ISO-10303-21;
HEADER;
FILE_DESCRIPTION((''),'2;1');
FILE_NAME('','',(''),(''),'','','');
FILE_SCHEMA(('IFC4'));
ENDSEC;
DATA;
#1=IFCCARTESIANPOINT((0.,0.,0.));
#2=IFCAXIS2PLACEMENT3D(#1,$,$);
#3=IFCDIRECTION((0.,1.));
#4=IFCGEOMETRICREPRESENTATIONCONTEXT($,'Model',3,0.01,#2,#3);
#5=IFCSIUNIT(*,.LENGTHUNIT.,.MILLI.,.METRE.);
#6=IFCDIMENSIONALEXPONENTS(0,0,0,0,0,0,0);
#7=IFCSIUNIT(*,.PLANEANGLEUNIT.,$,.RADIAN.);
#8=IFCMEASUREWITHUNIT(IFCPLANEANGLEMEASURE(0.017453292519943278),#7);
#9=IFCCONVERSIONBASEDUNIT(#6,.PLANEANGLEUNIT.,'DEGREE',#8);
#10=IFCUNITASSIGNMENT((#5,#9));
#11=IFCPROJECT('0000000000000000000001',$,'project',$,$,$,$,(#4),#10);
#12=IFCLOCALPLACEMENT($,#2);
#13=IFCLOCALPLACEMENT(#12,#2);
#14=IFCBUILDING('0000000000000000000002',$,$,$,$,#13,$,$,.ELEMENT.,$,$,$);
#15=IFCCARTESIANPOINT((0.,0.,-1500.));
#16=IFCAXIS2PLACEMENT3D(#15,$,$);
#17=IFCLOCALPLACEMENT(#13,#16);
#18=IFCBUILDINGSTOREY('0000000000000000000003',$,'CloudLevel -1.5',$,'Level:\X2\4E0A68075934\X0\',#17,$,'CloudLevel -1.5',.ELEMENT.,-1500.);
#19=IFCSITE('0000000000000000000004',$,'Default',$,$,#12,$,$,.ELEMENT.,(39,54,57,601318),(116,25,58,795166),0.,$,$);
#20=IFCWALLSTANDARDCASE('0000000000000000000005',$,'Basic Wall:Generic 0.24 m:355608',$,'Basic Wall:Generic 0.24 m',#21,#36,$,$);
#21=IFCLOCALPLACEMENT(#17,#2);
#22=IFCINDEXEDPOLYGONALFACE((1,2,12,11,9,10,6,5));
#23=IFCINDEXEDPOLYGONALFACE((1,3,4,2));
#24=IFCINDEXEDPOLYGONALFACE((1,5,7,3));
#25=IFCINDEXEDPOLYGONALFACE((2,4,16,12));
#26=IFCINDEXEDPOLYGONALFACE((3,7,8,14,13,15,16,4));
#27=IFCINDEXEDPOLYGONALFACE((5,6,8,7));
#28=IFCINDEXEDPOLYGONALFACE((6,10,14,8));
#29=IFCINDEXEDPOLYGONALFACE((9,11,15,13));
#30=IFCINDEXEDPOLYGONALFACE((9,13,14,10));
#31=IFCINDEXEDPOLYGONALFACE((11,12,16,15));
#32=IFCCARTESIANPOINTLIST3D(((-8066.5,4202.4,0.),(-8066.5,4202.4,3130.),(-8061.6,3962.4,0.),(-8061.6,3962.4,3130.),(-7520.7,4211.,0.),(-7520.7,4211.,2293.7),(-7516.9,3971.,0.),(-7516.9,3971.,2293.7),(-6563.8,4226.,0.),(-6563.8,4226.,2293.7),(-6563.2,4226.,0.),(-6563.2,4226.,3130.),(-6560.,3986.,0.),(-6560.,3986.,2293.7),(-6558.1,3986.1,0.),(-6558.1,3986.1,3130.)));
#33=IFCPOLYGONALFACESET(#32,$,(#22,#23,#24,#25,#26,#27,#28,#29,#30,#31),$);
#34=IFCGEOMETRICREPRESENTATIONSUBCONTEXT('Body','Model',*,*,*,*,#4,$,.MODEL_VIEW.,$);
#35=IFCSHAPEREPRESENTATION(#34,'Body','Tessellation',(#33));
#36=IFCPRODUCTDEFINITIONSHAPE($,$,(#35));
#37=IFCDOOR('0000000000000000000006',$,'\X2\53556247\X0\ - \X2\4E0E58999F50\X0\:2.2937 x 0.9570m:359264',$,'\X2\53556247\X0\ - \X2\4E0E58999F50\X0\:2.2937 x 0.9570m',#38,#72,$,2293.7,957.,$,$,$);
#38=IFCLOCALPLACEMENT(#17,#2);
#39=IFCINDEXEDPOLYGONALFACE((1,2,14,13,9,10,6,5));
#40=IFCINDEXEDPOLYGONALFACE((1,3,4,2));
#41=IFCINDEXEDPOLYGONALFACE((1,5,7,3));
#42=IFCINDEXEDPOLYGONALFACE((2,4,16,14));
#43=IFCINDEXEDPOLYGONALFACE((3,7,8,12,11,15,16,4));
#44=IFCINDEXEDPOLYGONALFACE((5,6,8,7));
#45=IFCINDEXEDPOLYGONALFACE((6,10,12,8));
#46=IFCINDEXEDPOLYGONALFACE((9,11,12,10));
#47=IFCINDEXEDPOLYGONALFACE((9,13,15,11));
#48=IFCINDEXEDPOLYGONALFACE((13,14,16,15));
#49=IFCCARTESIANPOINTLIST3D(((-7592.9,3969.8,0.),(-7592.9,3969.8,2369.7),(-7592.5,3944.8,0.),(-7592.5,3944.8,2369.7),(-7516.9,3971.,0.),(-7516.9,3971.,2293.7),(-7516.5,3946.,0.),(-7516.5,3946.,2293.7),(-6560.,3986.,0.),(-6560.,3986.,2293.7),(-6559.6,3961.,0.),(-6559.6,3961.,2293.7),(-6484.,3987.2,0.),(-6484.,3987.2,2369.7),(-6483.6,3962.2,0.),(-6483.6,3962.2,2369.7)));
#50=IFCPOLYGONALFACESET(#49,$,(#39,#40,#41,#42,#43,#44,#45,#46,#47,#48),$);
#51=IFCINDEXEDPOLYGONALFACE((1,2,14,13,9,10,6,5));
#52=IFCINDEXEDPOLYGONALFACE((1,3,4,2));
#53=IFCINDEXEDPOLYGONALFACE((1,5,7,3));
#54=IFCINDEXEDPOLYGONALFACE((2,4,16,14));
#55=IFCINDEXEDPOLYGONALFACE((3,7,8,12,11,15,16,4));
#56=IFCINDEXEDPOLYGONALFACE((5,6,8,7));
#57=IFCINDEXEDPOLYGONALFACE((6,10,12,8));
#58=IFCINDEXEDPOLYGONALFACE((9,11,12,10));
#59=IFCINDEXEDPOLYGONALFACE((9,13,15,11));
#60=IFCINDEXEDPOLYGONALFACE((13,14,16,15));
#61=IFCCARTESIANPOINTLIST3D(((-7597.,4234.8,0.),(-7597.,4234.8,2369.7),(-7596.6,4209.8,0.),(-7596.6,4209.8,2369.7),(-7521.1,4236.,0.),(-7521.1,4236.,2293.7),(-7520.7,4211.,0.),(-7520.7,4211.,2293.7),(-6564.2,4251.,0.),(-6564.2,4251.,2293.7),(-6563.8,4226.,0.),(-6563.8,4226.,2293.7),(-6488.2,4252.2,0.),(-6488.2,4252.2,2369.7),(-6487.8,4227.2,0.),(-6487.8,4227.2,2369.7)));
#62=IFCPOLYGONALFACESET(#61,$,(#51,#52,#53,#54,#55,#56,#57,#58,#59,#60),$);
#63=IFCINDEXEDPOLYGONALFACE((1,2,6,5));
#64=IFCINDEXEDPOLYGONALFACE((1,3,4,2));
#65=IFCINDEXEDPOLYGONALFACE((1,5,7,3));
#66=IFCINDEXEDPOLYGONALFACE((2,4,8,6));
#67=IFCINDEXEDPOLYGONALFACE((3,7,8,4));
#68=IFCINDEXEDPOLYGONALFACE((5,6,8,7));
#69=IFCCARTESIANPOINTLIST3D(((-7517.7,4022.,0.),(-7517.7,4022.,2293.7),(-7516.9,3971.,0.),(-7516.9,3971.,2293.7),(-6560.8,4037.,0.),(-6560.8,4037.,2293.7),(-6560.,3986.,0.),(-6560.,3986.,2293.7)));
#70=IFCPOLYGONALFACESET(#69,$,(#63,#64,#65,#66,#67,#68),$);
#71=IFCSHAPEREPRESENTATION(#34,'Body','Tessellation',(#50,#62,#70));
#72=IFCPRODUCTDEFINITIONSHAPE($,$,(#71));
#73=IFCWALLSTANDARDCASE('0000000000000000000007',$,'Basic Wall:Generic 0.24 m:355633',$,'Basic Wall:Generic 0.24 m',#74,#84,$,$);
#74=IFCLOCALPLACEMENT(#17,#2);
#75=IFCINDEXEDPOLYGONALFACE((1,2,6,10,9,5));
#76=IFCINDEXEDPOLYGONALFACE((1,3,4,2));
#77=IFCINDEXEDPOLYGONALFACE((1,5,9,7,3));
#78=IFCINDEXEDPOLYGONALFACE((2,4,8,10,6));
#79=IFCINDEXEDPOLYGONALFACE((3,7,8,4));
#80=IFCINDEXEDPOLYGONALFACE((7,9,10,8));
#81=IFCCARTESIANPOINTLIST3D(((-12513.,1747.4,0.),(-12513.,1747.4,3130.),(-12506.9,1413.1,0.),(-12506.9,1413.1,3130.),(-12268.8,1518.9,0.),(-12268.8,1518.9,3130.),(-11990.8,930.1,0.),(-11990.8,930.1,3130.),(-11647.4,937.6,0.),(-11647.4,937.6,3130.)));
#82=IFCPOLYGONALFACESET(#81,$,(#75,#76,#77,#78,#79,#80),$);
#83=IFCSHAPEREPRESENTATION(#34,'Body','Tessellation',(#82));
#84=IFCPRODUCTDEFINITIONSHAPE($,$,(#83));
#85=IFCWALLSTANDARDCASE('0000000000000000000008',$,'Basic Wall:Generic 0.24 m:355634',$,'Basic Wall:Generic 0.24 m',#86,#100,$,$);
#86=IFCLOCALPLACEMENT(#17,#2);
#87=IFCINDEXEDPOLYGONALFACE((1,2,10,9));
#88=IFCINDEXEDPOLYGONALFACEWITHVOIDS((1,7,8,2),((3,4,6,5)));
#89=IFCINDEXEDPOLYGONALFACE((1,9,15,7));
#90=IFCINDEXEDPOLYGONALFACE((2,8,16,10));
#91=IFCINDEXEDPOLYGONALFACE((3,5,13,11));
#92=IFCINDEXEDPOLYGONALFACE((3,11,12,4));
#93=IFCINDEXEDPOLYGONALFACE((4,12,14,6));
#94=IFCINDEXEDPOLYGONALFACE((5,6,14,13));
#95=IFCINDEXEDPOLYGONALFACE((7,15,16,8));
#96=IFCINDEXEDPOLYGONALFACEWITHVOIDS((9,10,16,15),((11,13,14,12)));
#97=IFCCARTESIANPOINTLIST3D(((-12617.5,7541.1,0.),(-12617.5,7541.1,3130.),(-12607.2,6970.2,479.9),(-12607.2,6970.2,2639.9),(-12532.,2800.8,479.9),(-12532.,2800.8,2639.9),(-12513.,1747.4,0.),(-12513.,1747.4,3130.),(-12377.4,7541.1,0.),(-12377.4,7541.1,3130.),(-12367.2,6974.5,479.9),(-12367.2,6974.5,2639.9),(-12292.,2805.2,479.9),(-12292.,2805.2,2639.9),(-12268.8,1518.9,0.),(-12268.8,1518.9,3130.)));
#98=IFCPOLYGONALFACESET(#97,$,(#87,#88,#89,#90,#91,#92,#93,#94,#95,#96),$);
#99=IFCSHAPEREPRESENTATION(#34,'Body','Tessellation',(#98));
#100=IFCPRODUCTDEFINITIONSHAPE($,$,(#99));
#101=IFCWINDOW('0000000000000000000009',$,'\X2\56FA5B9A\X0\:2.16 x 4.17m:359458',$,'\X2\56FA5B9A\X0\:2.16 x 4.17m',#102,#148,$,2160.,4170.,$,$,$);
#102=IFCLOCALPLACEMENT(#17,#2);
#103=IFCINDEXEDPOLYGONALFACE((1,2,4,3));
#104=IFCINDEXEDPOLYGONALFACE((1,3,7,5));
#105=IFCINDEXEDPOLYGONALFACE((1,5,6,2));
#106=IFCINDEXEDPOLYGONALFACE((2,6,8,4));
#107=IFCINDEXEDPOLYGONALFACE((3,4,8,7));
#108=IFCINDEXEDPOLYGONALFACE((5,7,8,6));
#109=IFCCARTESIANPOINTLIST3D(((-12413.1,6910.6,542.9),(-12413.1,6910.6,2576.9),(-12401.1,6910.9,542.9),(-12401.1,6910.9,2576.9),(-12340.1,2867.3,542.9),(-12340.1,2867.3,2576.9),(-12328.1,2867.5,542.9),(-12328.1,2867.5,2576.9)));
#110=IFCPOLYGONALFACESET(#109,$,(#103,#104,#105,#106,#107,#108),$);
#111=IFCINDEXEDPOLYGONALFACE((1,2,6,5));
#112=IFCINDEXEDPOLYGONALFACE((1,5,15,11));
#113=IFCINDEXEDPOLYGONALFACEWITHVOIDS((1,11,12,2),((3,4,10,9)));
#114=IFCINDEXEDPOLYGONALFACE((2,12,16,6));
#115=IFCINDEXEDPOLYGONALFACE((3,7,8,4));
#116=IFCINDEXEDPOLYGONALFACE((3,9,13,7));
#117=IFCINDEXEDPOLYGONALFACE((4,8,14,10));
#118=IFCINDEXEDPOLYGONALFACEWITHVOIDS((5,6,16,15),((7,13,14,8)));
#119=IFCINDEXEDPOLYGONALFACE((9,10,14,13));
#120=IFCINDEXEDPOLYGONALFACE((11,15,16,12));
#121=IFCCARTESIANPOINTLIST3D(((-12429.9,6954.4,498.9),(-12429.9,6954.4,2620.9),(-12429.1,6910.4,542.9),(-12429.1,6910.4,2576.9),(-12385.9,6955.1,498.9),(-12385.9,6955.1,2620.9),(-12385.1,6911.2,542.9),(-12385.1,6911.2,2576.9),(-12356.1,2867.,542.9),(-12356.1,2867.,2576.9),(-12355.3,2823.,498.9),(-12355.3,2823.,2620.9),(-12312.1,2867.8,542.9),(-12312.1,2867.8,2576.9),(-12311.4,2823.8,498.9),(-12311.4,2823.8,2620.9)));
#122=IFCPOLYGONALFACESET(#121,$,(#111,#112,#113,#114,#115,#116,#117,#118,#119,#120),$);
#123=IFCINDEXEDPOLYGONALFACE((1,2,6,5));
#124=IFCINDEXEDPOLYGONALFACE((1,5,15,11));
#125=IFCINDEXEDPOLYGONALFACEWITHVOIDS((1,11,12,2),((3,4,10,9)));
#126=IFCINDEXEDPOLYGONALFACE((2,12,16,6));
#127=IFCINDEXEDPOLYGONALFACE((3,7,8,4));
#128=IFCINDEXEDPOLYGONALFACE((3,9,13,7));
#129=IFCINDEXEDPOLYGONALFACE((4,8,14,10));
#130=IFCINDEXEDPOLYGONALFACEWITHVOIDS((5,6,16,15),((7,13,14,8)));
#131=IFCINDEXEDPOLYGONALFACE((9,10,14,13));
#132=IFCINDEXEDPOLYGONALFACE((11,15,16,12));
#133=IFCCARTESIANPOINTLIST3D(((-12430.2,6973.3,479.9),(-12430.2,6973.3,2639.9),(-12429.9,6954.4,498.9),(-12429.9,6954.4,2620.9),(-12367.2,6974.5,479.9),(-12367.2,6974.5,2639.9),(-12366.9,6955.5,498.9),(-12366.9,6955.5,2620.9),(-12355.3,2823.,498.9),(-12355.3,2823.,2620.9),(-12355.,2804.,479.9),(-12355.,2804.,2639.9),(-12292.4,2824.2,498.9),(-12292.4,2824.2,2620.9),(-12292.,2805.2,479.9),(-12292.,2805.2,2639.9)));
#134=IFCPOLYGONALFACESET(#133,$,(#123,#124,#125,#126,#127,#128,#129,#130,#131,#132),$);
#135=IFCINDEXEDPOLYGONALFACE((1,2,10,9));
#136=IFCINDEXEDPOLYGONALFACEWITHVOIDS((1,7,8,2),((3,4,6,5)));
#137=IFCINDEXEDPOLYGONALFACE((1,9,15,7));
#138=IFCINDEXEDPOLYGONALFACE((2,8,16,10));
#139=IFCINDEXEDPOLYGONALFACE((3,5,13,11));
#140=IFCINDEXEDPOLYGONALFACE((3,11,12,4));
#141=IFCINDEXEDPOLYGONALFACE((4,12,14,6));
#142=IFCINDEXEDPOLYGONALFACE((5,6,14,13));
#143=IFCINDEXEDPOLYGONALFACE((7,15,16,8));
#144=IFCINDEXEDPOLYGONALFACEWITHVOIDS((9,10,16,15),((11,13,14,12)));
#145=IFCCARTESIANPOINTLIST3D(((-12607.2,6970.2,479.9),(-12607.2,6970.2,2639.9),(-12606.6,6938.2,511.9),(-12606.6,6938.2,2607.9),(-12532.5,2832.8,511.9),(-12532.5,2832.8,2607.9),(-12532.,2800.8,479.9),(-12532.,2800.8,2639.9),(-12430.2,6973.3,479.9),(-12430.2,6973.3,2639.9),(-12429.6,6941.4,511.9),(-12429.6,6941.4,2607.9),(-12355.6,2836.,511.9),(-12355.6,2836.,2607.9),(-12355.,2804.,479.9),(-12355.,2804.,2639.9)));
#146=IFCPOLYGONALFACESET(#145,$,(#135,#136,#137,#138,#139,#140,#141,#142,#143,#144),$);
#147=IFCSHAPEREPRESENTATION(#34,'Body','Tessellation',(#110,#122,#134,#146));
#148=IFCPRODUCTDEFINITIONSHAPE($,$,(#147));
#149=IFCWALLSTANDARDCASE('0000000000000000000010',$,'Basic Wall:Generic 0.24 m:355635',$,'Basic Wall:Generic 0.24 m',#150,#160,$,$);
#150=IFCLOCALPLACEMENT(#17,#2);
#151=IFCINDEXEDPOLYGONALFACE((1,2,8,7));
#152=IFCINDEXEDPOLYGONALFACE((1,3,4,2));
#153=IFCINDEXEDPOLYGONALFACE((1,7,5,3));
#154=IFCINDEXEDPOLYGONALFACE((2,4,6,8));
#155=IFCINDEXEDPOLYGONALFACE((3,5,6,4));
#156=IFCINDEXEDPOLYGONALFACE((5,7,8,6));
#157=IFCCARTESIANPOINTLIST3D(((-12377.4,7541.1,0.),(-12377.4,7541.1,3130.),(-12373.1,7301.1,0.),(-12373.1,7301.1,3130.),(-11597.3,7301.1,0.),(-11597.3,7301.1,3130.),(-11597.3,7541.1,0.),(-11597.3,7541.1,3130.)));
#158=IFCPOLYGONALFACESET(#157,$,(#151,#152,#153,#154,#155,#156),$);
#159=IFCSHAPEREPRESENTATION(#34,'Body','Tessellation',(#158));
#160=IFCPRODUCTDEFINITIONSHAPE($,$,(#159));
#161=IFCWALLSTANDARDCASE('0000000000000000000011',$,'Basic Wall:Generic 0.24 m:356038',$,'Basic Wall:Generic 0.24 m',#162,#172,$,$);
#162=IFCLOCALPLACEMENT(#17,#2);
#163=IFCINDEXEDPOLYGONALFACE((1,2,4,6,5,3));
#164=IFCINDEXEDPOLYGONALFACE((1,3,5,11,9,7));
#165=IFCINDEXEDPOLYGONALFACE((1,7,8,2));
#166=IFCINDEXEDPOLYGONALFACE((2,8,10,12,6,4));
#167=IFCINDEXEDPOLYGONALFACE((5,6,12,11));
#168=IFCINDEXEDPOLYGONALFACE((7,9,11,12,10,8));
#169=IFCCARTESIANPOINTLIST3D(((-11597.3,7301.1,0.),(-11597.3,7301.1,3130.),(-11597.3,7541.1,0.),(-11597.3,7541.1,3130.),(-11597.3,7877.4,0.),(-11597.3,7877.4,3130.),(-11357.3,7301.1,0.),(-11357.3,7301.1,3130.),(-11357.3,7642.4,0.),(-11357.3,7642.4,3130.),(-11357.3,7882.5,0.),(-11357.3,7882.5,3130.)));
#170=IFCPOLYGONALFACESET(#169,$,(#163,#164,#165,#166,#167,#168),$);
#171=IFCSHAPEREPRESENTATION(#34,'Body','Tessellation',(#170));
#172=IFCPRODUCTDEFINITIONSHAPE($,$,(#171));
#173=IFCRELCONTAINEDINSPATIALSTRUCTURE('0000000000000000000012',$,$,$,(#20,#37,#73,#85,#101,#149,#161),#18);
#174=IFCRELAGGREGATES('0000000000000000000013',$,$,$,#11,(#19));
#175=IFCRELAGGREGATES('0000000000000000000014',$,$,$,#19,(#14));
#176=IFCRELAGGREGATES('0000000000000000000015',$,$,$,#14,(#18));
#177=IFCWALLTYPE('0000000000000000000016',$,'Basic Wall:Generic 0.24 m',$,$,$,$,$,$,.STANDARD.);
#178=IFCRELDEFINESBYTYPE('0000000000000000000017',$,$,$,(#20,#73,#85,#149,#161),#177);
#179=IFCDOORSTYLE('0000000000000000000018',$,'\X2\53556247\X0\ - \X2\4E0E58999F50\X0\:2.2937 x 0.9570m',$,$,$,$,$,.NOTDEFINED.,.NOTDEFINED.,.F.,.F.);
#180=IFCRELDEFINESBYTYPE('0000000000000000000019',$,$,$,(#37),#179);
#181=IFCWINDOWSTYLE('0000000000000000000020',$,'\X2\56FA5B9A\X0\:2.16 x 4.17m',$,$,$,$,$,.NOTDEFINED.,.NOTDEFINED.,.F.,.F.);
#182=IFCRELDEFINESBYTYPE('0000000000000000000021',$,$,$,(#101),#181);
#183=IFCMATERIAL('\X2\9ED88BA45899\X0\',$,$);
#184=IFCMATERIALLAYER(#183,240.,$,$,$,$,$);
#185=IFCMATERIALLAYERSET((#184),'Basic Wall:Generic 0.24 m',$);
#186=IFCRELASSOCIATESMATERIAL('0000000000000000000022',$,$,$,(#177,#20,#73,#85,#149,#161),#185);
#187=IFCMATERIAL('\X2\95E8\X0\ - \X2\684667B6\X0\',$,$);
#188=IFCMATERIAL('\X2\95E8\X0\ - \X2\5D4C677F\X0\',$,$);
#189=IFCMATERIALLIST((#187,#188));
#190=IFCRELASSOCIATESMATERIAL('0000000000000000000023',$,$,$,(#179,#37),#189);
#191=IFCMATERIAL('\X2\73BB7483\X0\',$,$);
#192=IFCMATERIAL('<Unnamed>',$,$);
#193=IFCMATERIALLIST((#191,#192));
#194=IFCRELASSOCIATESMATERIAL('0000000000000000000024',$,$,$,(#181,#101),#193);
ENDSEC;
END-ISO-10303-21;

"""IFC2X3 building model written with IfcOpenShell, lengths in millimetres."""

from ifc_helpers import new_model, entity, si_unit, converted_unit, direction, frame, frame_2d, origin, place, context, subcontext, project, spatial, polyline, rectangle, outline, extrude, source, transform, mapped, material, material_list, layer, layer_set, layer_usage, type_object, type_shapes, element, fill, save


model = new_model("IFC2X3")

# Units and contexts
model_context = context("Model", 3, precision=0.01, world=origin(), true_north=direction((0.0, 1.0)))
body_context = subcontext(model_context, "Body", "Model", "MODEL_VIEW")
ifc_project = project(units=[si_unit("LENGTHUNIT", "METRE", prefix="MILLI"), converted_unit("PLANEANGLEUNIT", "DEGREE", entity("IfcPlaneAngleMeasure", 0.017453292519943278), si_unit("PLANEANGLEUNIT", "RADIAN"), dimensions=[0, 0, 0, 0, 0, 0, 0])], contexts=[model_context])

# Site, building, storey
site_placement = place(None, origin())
site = spatial("IfcSite", under=ifc_project, at=site_placement, Name="Default", CompositionType="ELEMENT", RefLatitude=(39, 54, 57, 601318), RefLongitude=(116, 25, 58, 795166), RefElevation=0.0)
building_placement = place(site_placement, origin())
building = spatial("IfcBuilding", under=site, at=building_placement, CompositionType="ELEMENT")
storey_placement = place(building_placement, frame((0.0, 0.0, -1500.0)))
storey = spatial("IfcBuildingStorey", under=building, at=storey_placement, Name="CloudLevel -1.5", ObjectType="Level:上标头", LongName="CloudLevel -1.5", CompositionType="ELEMENT", Elevation=-1500.0)

# Shared definitions
ifc_material_1 = material(Name="默认墙")
ifc_layer_1 = layer(ifc_material_1, 240.0)
ifc_layer_set_1 = layer_set([ifc_layer_1], Name="Basic Wall:Generic 0.24 m")
ifc_layer_usage_1 = layer_usage(ifc_layer_set_1, "AXIS2", "NEGATIVE", 120.0)
wall_type_1 = type_object("IfcWallType", Name="Basic Wall:Generic 0.24 m", PredefinedType="STANDARD", material=ifc_layer_set_1)
ifc_material_2 = material(Name="门 - 框架")
ifc_material_3 = material(Name="门 - 嵌板")
ifc_material_list_1 = material_list([ifc_material_2, ifc_material_3])

# Wall, opening, door
wall_1_placement = place(storey_placement, frame((-8064.6, 4082.4, 0.0), z_axis=(0.0, 0.0, 1.0), x_axis=(0.999876, 0.015736, 0.0)))
wall_1 = element("IfcWallStandardCase", 1, at=wall_1_placement, inside=storey, type_object=wall_type_1, material=ifc_layer_usage_1, Name="Basic Wall:Generic 0.24 m:355608", ObjectType="Basic Wall:Generic 0.24 m", context=body_context, shape_type="SweptSolid", body=[
    extrude(outline(polyline([(1.1, -120.0), (341.1, -120.0), (1504.8, -120.0), (1503.5, 120.0), (0.0, 120.0), (1.1, -120.0)])), origin(), (0.0, 0.0, 1.0), 3130.0),
])
opening_1_placement = place(wall_1_placement, frame((1502.9, 120.0, 0.0)))
opening_1 = element("IfcOpeningElement", 2, at=opening_1_placement, cuts=wall_1, ObjectType="Opening", context=body_context, shape_type="SweptSolid", body=[
    extrude(rectangle(XDim=957.0, YDim=2293.7, at=frame_2d((1146.9, 478.5), x_axis=(0.0, -1.0))), frame((0.0, 0.0, 0.0), z_axis=(0.0, -1.0, 0.0), x_axis=(0.0, 0.0, 1.0)), (0.0, 0.0, 1.0), 240.0),
])
door_style_1 = type_object("IfcDoorStyle", Name="单扇 - 与墙齐:2.2937 x 0.9570m", ConstructionType="NOTDEFINED", OperationType="NOTDEFINED", ParameterTakesPrecedence=False, Sizeable=False, material=ifc_material_list_1)
shared_shape_1 = source(origin(), body_context, "Body", "SweptSolid", [
    extrude(outline(polyline([(-554.5, -1203.9), (554.5, -1203.9), (554.5, 1165.9), (478.5, 1165.9), (478.5, -1127.9), (-478.5, -1127.9), (-478.5, 1165.9), (-554.5, 1165.9), (-554.5, -1203.9)])), frame((478.5, 265.0, 1165.9), z_axis=(0.0, -1.0, 0.0), x_axis=(-1.0, 0.0, 0.0)), (0.0, 0.0, 1.0), 25.0),
    extrude(outline(polyline([(-1203.9, -554.5), (1165.9, -554.5), (1165.9, -478.5), (-1127.9, -478.5), (-1127.9, 478.5), (1165.9, 478.5), (1165.9, 554.5), (-1203.9, 554.5), (-1203.9, -554.5)])), frame((478.5, 0.0, 1165.9), z_axis=(0.0, -1.0, 0.0), x_axis=(0.0, 0.0, -1.0)), (0.0, 0.0, 1.0), 25.0),
    extrude(rectangle(XDim=957.0, YDim=51.0, at=frame_2d((0.0, 0.0), x_axis=(1.0, 0.0))), frame((478.5, 214.5, 0.0)), (0.0, 0.0, 1.0), 2293.7),
])
type_shapes(door_style_1, [shared_shape_1])
door_1_placement = place(opening_1_placement, frame((0.0, 0.0, 0.0), z_axis=(0.0, 0.0, 1.0), x_axis=(-1.0, 0.0, 0.0)))
door_1 = element("IfcDoor", 3, at=door_1_placement, inside=storey, type_object=door_style_1, material=ifc_material_list_1, Name="单扇 - 与墙齐:2.2937 x 0.9570m:359264", ObjectType="单扇 - 与墙齐:2.2937 x 0.9570m", OverallHeight=2293.7, OverallWidth=957.0, context=body_context, shape_type="MappedRepresentation", body=[
    mapped(shared_shape_1, transform((0.0, 0.0, 0.0), scale=1.0)),
])
fill(opening_1, door_1)

# Wall
wall_2_placement = place(storey_placement, frame((-11729.4, 849.9, 0.0), z_axis=(0.0, 0.0, 1.0), x_axis=(-0.730218, 0.683214, 0.0)))
element("IfcWallStandardCase", 4, at=wall_2_placement, inside=storey, type_object=wall_type_1, material=ifc_layer_usage_1, Name="Basic Wall:Generic 0.24 m:355633", ObjectType="Basic Wall:Generic 0.24 m", context=body_context, shape_type="SweptSolid", body=[
    extrude(outline(polyline([(1185.3, -120.0), (952.5, 120.0), (245.6, 120.0), (0.0, -120.0), (850.9, -120.0), (1185.3, -120.0)])), origin(), (0.0, 0.0, 1.0), 3130.0),
])

# Wall, opening, window
wall_3_placement = place(storey_placement, frame((-12388.8, 1516.8, 0.0), z_axis=(0.0, 0.0, 1.0), x_axis=(-0.018033, 0.999837, 0.0)))
wall_3 = element("IfcWallStandardCase", 5, at=wall_3_placement, inside=storey, type_object=wall_type_1, material=ifc_layer_usage_1, Name="Basic Wall:Generic 0.24 m:355634", ObjectType="Basic Wall:Generic 0.24 m", context=body_context, shape_type="SweptSolid", body=[
    extrude(outline(polyline([(6023.2, -120.0), (6027.5, 120.0), (301.7, 120.0), (232.8, 120.0), (0.0, -120.0), (5783.1, -120.0), (6023.2, -120.0)])), origin(), (0.0, 0.0, 1.0), 3130.0),
])
opening_2_placement = place(wall_3_placement, frame((5456.4, 120.0, 479.9)))
opening_2 = element("IfcOpeningElement", 6, at=opening_2_placement, cuts=wall_3, ObjectType="Opening", context=body_context, shape_type="SweptSolid", body=[
    extrude(rectangle(XDim=2160.0, YDim=4170.0, at=frame_2d((1080.0, 2085.0), x_axis=(1.0, 0.0))), frame((0.0, 0.0, 0.0), z_axis=(0.0, -1.0, 0.0), x_axis=(0.0, 0.0, 1.0)), (0.0, 0.0, 1.0), 240.0),
])
ifc_material_4 = material(Name="玻璃")
ifc_material_5 = material(Name="<Unnamed>")
ifc_material_list_2 = material_list([ifc_material_4, ifc_material_5])
window_style = type_object("IfcWindowStyle", Name="固定:2.16 x 4.17m", ConstructionType="NOTDEFINED", OperationType="NOTDEFINED", ParameterTakesPrecedence=False, Sizeable=False, material=ifc_material_list_2)
shared_shape_2 = source(origin(), body_context, "Body", "SweptSolid", [
    extrude(rectangle(XDim=4044.0, YDim=12.0, at=frame_2d((0.0, 0.0), x_axis=(1.0, 0.0))), frame((2085.0, 225.0, 63.0), z_axis=(0.0, 0.0, 1.0), x_axis=(-1.0, 0.0, 0.0)), (0.0, 0.0, 1.0), 2034.0),
    extrude(outline(polyline([(-2066.0, -1061.0), (2066.0, -1061.0), (2066.0, 1061.0), (-2066.0, 1061.0), (-2066.0, -1061.0)]), holes=[polyline([(-2022.0, -1017.0), (-2022.0, 1017.0), (2022.0, 1017.0), (2022.0, -1017.0), (-2022.0, -1017.0)])]), frame((2085.0, 247.0, 1080.0), z_axis=(0.0, -1.0, 0.0), x_axis=(-1.0, 0.0, 0.0)), (0.0, 0.0, 1.0), 44.0),
    extrude(outline(polyline([(-2085.0, -1080.0), (2085.0, -1080.0), (2085.0, 1080.0), (-2085.0, 1080.0), (-2085.0, -1080.0)]), holes=[polyline([(-2066.0, -1061.0), (-2066.0, 1061.0), (2066.0, 1061.0), (2066.0, -1061.0), (-2066.0, -1061.0)])]), frame((2085.0, 266.0, 1080.0), z_axis=(0.0, -1.0, 0.0), x_axis=(-1.0, 0.0, 0.0)), (0.0, 0.0, 1.0), 63.0),
    extrude(outline(polyline([(-2085.0, -1080.0), (2085.0, -1080.0), (2085.0, 1080.0), (-2085.0, 1080.0), (-2085.0, -1080.0)]), holes=[polyline([(-2053.0, -1048.0), (-2053.0, 1048.0), (2053.0, 1048.0), (2053.0, -1048.0), (-2053.0, -1048.0)])]), frame((2085.0, 203.0, 1080.0), z_axis=(0.0, -1.0, 0.0), x_axis=(-1.0, 0.0, 0.0)), (0.0, 0.0, 1.0), 177.0),
])
type_shapes(window_style, [shared_shape_2])
window_placement = place(opening_2_placement, frame((0.0, 26.0, 0.0), z_axis=(0.0, 0.0, 1.0), x_axis=(-1.0, 0.0, 0.0)))
window = element("IfcWindow", 7, at=window_placement, inside=storey, type_object=window_style, material=ifc_material_list_2, Name="固定:2.16 x 4.17m:359458", ObjectType="固定:2.16 x 4.17m", OverallHeight=2160.0, OverallWidth=4170.0, context=body_context, shape_type="MappedRepresentation", body=[
    mapped(shared_shape_2, transform((0.0, 0.0, 0.0), scale=1.0)),
])
fill(opening_2, window)

# Walls
wall_4_placement = place(storey_placement, frame((-11597.3, 7421.1, 0.0), z_axis=(0.0, 0.0, 1.0), x_axis=(-1.0, 0.0, 0.0)))
element("IfcWallStandardCase", 8, at=wall_4_placement, inside=storey, type_object=wall_type_1, material=ifc_layer_usage_1, Name="Basic Wall:Generic 0.24 m:355635", ObjectType="Basic Wall:Generic 0.24 m", context=body_context, shape_type="SweptSolid", body=[
    extrude(outline(polyline([(780.2, -120.0), (775.8, 120.0), (0.0, 120.0), (0.0, -120.0), (780.2, -120.0)])), origin(), (0.0, 0.0, 1.0), 3130.0),
])
wall_5_placement = place(storey_placement, frame((-11477.3, 7301.1, 0.0), z_axis=(0.0, 0.0, 1.0), x_axis=(0.0, 1.0, 0.0)))
element("IfcWallStandardCase", 9, at=wall_5_placement, inside=storey, type_object=wall_type_1, material=ifc_layer_usage_1, Name="Basic Wall:Generic 0.24 m:356038", ObjectType="Basic Wall:Generic 0.24 m", context=body_context, shape_type="SweptSolid", body=[
    extrude(outline(polyline([(581.3, -120.0), (576.3, 120.0), (240.0, 120.0), (0.0, 120.0), (0.0, -120.0), (341.3, -120.0), (581.3, -120.0)])), origin(), (0.0, 0.0, 1.0), 3130.0),
])

save(model, "model.ifc")
